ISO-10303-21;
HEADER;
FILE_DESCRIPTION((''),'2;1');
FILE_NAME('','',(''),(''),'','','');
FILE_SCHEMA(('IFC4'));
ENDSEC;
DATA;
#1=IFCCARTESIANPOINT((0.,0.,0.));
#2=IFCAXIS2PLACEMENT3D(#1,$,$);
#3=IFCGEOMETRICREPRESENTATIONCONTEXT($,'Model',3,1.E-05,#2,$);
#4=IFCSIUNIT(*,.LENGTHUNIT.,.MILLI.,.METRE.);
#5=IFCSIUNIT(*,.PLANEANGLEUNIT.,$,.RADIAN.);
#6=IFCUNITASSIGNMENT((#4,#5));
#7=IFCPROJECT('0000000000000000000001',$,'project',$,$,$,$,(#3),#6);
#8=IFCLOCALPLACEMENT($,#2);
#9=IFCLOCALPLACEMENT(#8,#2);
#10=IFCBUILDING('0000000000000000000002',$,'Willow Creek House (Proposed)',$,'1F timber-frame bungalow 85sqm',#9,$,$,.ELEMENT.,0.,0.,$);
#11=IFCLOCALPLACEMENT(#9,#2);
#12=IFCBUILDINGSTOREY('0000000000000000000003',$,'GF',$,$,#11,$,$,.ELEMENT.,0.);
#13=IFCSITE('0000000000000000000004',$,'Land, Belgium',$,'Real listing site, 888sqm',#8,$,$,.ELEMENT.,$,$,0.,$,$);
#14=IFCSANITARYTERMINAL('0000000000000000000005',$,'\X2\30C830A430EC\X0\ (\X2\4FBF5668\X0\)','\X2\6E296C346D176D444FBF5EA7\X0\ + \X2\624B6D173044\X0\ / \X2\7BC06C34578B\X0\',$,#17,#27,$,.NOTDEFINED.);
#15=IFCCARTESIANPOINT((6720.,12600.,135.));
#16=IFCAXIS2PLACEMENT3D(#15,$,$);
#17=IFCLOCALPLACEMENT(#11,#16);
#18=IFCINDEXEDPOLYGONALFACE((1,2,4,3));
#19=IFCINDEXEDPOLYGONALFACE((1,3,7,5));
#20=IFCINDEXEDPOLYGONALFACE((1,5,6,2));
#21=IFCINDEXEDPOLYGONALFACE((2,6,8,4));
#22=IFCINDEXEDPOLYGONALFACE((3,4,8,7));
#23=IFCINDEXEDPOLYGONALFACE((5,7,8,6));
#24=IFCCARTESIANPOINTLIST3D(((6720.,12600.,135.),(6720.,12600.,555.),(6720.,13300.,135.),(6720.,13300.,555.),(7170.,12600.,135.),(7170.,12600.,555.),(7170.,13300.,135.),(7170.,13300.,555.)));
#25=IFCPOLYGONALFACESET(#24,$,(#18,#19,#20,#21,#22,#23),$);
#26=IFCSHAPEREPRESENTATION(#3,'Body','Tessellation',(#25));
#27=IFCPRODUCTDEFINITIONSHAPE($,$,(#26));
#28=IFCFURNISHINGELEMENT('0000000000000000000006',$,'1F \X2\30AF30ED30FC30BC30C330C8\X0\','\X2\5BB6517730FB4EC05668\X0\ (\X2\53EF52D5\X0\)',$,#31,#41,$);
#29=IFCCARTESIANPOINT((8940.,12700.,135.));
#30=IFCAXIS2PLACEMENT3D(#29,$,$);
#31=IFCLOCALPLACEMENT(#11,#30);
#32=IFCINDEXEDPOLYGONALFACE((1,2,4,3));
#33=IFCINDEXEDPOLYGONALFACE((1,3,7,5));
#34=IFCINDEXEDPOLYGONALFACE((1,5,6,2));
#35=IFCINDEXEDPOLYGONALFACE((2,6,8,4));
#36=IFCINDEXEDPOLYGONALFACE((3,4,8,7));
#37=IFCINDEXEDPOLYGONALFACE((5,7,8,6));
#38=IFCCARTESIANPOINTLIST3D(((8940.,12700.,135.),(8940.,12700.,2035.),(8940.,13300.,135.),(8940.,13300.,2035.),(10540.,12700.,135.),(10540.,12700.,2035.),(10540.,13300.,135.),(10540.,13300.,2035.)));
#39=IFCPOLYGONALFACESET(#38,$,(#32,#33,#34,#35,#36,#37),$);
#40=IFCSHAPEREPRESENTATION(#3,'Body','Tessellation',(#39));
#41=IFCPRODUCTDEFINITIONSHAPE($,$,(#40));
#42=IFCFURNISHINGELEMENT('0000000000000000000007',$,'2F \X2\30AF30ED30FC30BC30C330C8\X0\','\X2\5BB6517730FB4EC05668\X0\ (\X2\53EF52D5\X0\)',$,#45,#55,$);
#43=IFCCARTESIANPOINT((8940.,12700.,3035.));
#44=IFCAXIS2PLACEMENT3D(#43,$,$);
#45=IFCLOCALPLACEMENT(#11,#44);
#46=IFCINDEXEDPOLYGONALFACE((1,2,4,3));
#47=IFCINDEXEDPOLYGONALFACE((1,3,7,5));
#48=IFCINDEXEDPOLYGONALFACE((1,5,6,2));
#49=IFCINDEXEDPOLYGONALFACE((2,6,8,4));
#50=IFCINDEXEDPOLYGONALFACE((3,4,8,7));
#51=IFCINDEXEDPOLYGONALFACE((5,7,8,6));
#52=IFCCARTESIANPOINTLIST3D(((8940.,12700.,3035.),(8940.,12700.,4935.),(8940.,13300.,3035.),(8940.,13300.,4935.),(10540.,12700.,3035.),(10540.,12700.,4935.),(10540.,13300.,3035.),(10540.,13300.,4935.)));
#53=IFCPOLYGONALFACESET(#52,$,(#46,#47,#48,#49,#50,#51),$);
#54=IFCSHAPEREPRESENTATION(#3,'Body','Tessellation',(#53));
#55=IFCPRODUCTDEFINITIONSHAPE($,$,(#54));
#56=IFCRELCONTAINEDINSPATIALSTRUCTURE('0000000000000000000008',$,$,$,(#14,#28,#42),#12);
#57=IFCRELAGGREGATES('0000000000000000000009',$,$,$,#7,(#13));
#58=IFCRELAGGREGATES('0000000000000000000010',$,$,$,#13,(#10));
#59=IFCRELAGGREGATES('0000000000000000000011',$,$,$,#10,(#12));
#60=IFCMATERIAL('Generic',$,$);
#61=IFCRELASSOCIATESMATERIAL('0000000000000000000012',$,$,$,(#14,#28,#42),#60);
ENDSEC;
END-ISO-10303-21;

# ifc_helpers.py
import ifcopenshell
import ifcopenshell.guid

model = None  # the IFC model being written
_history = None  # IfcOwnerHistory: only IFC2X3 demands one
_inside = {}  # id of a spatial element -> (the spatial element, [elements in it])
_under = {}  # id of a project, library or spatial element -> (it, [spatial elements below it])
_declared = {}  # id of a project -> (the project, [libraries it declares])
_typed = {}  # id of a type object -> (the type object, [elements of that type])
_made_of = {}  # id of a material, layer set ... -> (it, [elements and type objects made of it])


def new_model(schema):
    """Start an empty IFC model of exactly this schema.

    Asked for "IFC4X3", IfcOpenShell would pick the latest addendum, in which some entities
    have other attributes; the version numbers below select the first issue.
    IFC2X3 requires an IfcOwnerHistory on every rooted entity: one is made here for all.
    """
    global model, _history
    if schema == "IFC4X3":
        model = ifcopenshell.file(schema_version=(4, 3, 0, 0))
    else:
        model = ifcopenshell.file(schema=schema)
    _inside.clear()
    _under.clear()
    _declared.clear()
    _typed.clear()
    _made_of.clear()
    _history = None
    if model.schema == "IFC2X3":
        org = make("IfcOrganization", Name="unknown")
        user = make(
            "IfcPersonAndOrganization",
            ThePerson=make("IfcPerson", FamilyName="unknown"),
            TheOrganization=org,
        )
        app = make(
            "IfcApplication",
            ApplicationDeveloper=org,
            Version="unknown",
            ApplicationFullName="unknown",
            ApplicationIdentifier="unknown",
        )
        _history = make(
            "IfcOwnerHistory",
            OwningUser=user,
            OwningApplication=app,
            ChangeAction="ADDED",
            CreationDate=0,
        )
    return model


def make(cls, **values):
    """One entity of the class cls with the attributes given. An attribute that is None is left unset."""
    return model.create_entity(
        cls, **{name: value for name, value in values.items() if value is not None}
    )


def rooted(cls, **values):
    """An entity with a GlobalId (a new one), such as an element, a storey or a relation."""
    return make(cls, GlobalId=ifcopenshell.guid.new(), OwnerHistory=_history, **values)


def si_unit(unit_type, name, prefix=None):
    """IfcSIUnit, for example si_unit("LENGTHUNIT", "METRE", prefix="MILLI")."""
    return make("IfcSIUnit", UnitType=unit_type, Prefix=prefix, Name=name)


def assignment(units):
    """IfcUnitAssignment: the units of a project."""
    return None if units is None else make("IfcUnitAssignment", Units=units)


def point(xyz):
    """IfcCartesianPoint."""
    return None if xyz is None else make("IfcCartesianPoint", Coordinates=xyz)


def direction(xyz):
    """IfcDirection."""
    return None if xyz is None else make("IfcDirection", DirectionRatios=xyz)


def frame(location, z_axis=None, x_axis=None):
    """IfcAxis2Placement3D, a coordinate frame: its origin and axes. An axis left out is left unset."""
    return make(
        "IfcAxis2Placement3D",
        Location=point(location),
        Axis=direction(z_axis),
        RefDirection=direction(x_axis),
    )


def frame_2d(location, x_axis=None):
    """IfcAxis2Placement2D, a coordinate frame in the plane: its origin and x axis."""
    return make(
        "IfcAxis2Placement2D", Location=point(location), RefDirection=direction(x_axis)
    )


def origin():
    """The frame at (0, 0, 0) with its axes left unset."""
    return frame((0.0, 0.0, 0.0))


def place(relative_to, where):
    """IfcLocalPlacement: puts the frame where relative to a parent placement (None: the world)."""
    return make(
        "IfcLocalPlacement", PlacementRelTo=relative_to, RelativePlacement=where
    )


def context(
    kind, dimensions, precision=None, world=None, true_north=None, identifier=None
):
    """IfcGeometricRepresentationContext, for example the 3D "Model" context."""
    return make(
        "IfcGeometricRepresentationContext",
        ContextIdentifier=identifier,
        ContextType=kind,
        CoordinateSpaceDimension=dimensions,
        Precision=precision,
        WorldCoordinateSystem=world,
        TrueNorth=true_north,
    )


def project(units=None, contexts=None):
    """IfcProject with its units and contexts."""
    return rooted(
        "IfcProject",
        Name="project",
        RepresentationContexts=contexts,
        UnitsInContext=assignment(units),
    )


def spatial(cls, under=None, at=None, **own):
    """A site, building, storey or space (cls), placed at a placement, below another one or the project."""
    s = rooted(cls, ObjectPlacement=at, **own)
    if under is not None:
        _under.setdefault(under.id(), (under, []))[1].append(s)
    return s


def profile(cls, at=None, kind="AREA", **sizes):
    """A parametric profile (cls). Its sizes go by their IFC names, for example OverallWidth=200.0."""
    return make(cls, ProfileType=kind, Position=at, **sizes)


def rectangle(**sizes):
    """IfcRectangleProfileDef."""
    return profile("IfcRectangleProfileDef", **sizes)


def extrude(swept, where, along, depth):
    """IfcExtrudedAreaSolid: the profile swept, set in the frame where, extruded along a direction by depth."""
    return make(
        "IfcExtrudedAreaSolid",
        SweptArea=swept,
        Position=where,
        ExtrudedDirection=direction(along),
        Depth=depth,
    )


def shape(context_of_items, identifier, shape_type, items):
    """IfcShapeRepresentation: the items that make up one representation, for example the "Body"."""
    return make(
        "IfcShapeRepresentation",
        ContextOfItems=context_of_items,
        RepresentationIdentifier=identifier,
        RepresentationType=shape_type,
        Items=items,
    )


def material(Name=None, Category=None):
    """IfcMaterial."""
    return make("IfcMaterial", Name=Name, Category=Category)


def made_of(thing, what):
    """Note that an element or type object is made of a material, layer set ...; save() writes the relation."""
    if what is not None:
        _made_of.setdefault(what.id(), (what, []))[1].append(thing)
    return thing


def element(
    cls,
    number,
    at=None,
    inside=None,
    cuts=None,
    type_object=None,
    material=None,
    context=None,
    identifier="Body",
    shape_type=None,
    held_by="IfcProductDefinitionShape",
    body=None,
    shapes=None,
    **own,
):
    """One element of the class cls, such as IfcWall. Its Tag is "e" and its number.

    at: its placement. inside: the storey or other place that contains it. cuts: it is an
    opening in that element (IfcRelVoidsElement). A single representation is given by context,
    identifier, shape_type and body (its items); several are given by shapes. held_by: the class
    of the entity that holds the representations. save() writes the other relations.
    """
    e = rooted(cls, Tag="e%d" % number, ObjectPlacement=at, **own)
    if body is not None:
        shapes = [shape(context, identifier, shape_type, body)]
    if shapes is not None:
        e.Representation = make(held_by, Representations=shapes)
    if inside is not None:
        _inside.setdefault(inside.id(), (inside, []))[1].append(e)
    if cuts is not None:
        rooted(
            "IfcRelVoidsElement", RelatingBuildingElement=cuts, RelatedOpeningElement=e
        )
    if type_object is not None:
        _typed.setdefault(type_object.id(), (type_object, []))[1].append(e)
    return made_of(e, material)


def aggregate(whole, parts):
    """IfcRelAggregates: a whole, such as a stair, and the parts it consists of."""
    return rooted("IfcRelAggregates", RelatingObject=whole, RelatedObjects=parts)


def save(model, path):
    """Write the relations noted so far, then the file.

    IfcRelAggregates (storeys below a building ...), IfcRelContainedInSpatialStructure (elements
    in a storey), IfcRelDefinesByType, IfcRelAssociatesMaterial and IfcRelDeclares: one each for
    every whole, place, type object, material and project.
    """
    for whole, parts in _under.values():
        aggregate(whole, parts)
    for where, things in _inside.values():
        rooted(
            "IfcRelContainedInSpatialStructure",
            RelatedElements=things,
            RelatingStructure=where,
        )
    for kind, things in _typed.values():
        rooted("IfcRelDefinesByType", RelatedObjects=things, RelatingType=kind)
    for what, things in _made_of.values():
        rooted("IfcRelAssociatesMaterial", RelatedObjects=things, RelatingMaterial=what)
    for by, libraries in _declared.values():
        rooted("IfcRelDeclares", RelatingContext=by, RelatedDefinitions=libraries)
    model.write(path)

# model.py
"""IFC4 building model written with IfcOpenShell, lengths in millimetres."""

from ifc_helpers import new_model, si_unit, frame, frame_2d, origin, place, context, project, spatial, rectangle, extrude, material, element, save


model = new_model("IFC4")

# Units and contexts
model_context = context("Model", 3, precision=1e-05, world=origin())
ifc_project = project(units=[si_unit("LENGTHUNIT", "METRE", prefix="MILLI"), si_unit("PLANEANGLEUNIT", "RADIAN")], contexts=[model_context])

# Site, building, storey
site_placement = place(None, origin())
site = spatial("IfcSite", under=ifc_project, at=site_placement, Name="Land, Belgium", ObjectType="Real listing site, 888sqm", CompositionType="ELEMENT", RefElevation=0.0)
building_placement = place(site_placement, origin())
building = spatial("IfcBuilding", under=site, at=building_placement, Name="Willow Creek House (Proposed)", ObjectType="1F timber-frame bungalow 85sqm", CompositionType="ELEMENT", ElevationOfRefHeight=0.0, ElevationOfTerrain=0.0)
storey_placement = place(building_placement, origin())
storey = spatial("IfcBuildingStorey", under=building, at=storey_placement, Name="GF", CompositionType="ELEMENT", Elevation=0.0)

# Sanitary terminal
ifc_material_1 = material(Name="Generic")
sanitary_terminal_1_placement = place(storey_placement, frame((6720.0, 12600.0, 135.0)))
element("IfcSanitaryTerminal", 1, at=sanitary_terminal_1_placement, inside=storey, material=ifc_material_1, Name="トイレ (便器)", Description="温水洗浄便座 + 手洗い / 節水型", PredefinedType="NOTDEFINED", context=model_context, shape_type="SweptSolid", body=[
    extrude(rectangle(XDim=450.0, YDim=700.0, at=frame_2d((225.0, 350.0))), frame((6720.0, 12600.0, 135.0)), (0.0, 0.0, 1.0), 420.0),
])

# Furnishing elements
furnishing_1_placement = place(storey_placement, frame((8940.0, 12700.0, 135.0)))
element("IfcFurnishingElement", 2, at=furnishing_1_placement, inside=storey, material=ifc_material_1, Name="1F クローゼット", Description="家具・什器 (可動)", context=model_context, shape_type="SweptSolid", body=[
    extrude(rectangle(XDim=1600.0, YDim=600.0, at=frame_2d((800.0, 300.0))), frame((8940.0, 12700.0, 135.0)), (0.0, 0.0, 1.0), 1900.0),
])
furnishing_2_placement = place(storey_placement, frame((8940.0, 12700.0, 3035.0)))
element("IfcFurnishingElement", 3, at=furnishing_2_placement, inside=storey, material=ifc_material_1, Name="2F クローゼット", Description="家具・什器 (可動)", context=model_context, shape_type="SweptSolid", body=[
    extrude(rectangle(XDim=1600.0, YDim=600.0, at=frame_2d((800.0, 300.0))), frame((8940.0, 12700.0, 3035.0)), (0.0, 0.0, 1.0), 1900.0),
])

save(model, "model.ifc")
